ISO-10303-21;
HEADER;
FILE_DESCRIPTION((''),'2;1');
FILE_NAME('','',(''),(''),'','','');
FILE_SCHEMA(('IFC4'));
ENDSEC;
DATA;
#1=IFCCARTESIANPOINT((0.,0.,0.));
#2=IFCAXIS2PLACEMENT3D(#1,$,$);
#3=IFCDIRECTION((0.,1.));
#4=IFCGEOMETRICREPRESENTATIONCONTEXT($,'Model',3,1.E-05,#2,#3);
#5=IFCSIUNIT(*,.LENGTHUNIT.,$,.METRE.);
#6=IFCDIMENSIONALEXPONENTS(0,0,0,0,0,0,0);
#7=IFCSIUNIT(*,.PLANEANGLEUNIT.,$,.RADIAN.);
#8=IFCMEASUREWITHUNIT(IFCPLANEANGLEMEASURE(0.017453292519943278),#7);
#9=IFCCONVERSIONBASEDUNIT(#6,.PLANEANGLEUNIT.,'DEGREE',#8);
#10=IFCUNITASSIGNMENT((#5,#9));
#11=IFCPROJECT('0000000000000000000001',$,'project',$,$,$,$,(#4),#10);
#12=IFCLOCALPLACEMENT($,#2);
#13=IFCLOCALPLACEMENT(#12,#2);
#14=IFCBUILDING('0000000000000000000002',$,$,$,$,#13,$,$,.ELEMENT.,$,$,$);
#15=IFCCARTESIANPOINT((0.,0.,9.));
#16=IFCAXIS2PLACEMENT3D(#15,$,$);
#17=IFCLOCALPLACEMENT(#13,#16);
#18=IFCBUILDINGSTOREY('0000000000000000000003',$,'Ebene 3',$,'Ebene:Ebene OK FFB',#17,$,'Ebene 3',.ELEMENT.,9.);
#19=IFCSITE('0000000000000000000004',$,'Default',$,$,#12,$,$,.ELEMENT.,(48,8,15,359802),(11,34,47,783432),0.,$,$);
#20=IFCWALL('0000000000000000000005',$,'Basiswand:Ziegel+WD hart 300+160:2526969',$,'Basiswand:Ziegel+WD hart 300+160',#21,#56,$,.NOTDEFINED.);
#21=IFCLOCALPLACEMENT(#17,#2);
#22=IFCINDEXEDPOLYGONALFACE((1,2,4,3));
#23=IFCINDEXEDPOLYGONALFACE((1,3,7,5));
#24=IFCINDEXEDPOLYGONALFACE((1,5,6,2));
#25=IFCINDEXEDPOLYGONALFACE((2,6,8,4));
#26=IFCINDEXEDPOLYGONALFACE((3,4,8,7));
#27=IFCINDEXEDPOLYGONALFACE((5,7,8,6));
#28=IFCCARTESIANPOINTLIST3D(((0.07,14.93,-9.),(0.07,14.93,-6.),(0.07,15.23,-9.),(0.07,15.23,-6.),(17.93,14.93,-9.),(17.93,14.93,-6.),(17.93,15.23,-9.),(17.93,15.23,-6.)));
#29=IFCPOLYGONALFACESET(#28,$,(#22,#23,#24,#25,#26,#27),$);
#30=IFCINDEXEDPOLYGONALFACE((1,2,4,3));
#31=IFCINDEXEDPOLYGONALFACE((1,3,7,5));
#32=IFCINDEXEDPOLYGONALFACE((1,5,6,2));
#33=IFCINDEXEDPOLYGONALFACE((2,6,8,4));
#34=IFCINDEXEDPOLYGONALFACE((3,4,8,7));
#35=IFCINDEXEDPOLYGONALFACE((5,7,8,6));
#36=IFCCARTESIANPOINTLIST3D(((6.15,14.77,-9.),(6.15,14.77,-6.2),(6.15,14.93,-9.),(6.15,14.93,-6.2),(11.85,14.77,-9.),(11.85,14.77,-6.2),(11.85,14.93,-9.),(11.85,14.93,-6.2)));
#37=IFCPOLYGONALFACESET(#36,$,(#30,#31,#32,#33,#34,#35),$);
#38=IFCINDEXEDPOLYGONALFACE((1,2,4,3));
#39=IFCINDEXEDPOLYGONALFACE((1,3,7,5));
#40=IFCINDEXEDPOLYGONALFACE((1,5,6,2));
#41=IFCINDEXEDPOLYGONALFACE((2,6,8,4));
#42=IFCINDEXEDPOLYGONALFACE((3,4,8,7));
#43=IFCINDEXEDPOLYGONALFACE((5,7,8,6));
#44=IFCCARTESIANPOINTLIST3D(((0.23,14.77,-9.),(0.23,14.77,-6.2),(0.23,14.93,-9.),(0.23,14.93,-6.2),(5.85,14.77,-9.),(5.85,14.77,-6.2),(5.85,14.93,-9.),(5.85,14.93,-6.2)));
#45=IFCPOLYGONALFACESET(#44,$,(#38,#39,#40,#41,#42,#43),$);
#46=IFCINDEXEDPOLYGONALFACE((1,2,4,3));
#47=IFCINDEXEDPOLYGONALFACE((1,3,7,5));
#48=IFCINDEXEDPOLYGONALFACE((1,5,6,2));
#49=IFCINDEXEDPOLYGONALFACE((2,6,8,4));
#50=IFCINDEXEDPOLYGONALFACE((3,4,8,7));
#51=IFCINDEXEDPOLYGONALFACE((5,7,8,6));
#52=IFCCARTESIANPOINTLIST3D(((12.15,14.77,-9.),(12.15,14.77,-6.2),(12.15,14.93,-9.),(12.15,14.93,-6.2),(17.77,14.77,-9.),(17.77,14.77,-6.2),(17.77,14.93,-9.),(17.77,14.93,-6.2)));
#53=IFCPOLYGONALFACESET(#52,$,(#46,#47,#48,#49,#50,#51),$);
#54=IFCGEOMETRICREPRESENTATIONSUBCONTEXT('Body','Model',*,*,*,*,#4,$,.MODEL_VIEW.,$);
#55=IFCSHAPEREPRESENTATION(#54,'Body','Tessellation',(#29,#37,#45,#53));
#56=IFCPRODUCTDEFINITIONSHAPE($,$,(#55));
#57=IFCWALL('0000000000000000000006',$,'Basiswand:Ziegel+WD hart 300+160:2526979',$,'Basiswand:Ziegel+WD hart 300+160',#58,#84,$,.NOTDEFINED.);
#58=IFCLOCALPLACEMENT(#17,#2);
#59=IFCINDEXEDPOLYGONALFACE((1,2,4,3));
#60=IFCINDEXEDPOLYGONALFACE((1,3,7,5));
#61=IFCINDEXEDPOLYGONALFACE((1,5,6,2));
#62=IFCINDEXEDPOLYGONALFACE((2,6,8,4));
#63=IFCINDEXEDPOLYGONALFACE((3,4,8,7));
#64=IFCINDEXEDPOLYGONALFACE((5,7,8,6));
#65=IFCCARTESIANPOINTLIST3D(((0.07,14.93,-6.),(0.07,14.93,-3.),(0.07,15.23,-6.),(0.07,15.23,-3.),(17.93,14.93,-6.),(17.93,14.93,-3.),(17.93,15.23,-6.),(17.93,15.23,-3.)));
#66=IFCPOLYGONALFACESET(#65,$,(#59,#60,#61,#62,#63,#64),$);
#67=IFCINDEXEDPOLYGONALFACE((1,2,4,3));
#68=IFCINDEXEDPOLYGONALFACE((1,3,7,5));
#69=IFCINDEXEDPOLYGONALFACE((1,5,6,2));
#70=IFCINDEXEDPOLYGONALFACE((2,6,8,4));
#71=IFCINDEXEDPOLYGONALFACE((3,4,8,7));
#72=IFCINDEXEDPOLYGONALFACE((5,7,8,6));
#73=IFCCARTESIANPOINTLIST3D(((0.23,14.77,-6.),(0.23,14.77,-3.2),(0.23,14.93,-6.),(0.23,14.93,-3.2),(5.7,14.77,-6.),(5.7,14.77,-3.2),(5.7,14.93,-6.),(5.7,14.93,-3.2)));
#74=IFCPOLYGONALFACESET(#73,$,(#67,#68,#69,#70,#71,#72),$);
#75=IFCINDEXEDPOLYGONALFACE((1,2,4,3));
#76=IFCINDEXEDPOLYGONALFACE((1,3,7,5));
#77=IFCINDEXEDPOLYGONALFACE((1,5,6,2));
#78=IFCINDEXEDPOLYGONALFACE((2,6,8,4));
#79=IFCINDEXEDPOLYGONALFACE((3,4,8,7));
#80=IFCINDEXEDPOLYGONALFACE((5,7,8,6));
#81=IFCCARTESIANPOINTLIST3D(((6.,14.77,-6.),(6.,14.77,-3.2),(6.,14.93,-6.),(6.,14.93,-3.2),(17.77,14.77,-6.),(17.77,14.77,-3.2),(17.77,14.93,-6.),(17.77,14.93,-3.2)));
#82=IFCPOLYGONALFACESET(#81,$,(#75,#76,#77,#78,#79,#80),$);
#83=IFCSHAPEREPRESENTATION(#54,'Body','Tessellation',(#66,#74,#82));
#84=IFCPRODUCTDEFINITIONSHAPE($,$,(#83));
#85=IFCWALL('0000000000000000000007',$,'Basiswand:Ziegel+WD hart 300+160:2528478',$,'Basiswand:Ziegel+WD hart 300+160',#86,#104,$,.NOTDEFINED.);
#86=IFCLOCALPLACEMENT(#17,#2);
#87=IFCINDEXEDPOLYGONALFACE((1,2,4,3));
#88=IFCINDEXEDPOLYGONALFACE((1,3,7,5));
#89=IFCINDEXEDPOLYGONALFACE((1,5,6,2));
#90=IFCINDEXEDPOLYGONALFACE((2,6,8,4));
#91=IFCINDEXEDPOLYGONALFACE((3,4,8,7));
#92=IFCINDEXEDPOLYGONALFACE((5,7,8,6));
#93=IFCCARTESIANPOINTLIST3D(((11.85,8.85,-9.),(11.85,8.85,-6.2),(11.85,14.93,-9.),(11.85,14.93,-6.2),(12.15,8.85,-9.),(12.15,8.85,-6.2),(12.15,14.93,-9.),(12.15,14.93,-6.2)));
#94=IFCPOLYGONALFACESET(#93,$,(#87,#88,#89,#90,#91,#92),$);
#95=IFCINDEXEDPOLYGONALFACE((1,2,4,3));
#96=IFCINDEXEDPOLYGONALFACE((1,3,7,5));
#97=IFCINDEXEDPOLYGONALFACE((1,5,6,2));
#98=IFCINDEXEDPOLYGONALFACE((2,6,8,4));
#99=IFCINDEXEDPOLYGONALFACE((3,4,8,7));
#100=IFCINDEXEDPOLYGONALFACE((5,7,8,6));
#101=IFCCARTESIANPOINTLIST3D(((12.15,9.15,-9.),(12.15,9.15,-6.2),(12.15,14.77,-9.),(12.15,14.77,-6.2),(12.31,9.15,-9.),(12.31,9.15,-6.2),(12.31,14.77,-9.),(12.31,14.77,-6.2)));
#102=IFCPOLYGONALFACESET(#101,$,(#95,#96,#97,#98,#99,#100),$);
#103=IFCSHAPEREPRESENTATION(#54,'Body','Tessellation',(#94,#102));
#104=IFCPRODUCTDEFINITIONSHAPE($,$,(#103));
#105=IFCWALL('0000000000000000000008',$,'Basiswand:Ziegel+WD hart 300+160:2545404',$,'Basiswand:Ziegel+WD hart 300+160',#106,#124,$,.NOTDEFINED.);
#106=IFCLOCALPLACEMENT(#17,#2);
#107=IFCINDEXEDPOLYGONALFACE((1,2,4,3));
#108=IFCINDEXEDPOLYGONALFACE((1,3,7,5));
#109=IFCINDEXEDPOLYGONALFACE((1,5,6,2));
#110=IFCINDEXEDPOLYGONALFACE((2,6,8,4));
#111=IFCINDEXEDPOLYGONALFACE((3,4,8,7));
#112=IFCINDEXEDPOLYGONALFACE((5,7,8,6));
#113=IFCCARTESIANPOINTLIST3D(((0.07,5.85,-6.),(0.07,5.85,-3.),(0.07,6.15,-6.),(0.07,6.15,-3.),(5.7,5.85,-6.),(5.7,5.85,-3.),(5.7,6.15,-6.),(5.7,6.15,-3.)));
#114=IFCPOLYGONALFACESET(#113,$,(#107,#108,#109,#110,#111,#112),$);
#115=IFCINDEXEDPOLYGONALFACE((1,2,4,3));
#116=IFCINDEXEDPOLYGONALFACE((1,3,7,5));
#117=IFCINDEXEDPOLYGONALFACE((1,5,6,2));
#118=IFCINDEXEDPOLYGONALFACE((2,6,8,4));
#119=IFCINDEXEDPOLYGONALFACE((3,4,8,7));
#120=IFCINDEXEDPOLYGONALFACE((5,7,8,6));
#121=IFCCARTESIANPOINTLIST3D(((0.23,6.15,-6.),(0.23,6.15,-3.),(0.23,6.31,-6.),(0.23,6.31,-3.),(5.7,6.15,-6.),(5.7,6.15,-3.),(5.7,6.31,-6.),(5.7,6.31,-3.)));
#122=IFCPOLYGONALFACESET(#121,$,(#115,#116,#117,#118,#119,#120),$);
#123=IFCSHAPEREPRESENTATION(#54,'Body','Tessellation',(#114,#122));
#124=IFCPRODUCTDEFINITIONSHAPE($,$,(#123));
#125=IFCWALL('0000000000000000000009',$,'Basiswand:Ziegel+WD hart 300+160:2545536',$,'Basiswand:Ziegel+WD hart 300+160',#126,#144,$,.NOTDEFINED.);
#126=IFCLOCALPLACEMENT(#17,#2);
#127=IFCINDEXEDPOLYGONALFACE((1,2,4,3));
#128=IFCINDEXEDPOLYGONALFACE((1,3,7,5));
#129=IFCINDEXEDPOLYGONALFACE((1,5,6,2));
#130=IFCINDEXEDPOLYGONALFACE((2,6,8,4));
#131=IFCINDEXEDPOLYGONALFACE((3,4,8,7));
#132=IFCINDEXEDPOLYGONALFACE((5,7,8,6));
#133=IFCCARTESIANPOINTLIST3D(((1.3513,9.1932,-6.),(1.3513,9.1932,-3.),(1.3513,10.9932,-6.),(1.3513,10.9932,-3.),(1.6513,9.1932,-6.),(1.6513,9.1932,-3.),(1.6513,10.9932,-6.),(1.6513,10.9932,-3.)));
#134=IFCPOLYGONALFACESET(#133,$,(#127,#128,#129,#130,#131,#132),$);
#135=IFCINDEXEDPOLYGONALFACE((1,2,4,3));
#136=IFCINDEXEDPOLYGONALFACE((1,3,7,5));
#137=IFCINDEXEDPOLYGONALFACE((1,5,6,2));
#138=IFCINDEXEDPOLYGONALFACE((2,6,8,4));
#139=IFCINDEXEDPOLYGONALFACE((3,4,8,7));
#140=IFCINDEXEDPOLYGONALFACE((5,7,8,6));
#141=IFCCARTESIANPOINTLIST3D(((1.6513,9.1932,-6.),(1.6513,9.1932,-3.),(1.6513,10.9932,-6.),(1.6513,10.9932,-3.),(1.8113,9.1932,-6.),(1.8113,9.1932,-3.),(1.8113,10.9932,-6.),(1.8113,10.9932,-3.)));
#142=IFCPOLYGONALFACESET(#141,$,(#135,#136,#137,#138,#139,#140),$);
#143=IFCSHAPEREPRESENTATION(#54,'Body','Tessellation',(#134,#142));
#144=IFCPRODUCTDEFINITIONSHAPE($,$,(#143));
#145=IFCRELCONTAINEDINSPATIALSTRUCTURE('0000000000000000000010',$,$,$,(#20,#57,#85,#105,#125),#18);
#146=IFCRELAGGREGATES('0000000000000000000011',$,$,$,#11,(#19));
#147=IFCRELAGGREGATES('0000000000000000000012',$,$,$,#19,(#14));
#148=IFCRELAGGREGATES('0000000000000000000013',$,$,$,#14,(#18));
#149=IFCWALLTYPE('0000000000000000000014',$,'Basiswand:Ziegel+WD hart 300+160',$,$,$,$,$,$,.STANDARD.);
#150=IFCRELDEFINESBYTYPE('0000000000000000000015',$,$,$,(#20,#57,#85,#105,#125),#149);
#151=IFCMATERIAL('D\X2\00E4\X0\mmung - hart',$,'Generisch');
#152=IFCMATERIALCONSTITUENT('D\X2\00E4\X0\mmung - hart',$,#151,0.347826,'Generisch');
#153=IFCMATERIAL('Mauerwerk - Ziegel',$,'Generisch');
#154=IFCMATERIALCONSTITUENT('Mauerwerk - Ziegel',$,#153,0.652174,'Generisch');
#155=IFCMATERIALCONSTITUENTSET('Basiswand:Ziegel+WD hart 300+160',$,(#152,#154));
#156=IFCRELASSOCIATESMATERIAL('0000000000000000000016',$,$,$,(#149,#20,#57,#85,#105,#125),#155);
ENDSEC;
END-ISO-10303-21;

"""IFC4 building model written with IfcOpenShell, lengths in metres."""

from ifc_helpers import new_model, entity, si_unit, converted_unit, direction, frame, origin, place, context, subcontext, project, spatial, indexed_curve, outline, extrude, material, constituent, constituent_set, type_object, element, save


model = new_model("IFC4")

# Units and contexts
model_context = context("Model", 3, precision=1e-05, world=origin(), true_north=direction((0.0, 1.0)))
body_context = subcontext(model_context, "Body", "Model", "MODEL_VIEW")
ifc_project = project(units=[si_unit("LENGTHUNIT", "METRE"), converted_unit("PLANEANGLEUNIT", "DEGREE", entity("IfcPlaneAngleMeasure", 0.017453292519943278), si_unit("PLANEANGLEUNIT", "RADIAN"), dimensions=[0, 0, 0, 0, 0, 0, 0])], contexts=[model_context])

# Site, building, storey
site_placement = place(None, origin())
site = spatial("IfcSite", under=ifc_project, at=site_placement, Name="Default", CompositionType="ELEMENT", RefLatitude=(48, 8, 15, 359802), RefLongitude=(11, 34, 47, 783432), RefElevation=0.0)
building_placement = place(site_placement, origin())
building = spatial("IfcBuilding", under=site, at=building_placement, CompositionType="ELEMENT")
storey_placement = place(building_placement, frame((0.0, 0.0, 9.0)))
storey = spatial("IfcBuildingStorey", under=building, at=storey_placement, Name="Ebene 3", ObjectType="Ebene:Ebene OK FFB", LongName="Ebene 3", CompositionType="ELEMENT", Elevation=9.0)

# Walls
ifc_material_1 = material(Name="Dämmung - hart", Category="Generisch")
ifc_constituent_1 = constituent(ifc_material_1, Name="Dämmung - hart", Category="Generisch", fraction=0.347826)
ifc_material_2 = material(Name="Mauerwerk - Ziegel", Category="Generisch")
ifc_constituent_2 = constituent(ifc_material_2, Name="Mauerwerk - Ziegel", Category="Generisch", fraction=0.652174)
ifc_constituent_set_1 = constituent_set(constituents=[ifc_constituent_1, ifc_constituent_2], Name="Basiswand:Ziegel+WD hart 300+160")
wall_type = type_object("IfcWallType", Name="Basiswand:Ziegel+WD hart 300+160", PredefinedType="STANDARD", material=ifc_constituent_set_1)
wall_1_placement = place(storey_placement, frame((17.77, 15.0, -9.0), z_axis=(0.0, 0.0, 1.0), x_axis=(-1.0, 0.0, 0.0)))
element("IfcWall", 1, at=wall_1_placement, inside=storey, type_object=wall_type, material=ifc_constituent_set_1, Name="Basiswand:Ziegel+WD hart 300+160:2526969", ObjectType="Basiswand:Ziegel+WD hart 300+160", PredefinedType="NOTDEFINED", context=body_context, shape_type="SweptSolid", body=[
    extrude(outline(indexed_curve([(-0.15, -8.93), (0.15, -8.93), (0.15, 8.93), (-0.15, 8.93), (-0.15, -8.93)], self_intersect=False)), frame((8.77, -0.08, 0.0), z_axis=(0.0, 0.0, 1.0), x_axis=(0.0, 1.0, 0.0)), (0.0, 0.0, 1.0), 3.0),
    extrude(outline(indexed_curve([(-2.85, -0.08), (2.85, -0.08), (2.85, 0.08), (-2.85, 0.08), (-2.85, -0.08)], self_intersect=False)), frame((8.77, 0.15, 0.0)), (0.0, 0.0, 1.0), 2.8),
    extrude(outline(indexed_curve([(-2.81, -0.08), (2.81, -0.08), (2.81, 0.08), (-2.81, 0.08), (-2.81, -0.08)], self_intersect=False)), frame((14.73, 0.15, 0.0), z_axis=(0.0, 0.0, 1.0), x_axis=(-1.0, 0.0, 0.0)), (0.0, 0.0, 1.0), 2.8),
    extrude(outline(indexed_curve([(-2.81, -0.08), (2.81, -0.08), (2.81, 0.08), (-2.81, 0.08), (-2.81, -0.08)], self_intersect=False)), frame((2.81, 0.15, 0.0)), (0.0, 0.0, 1.0), 2.8),
])
wall_2_placement = place(storey_placement, frame((17.77, 15.0, -6.0), z_axis=(0.0, 0.0, 1.0), x_axis=(-1.0, 0.0, 0.0)))
element("IfcWall", 2, at=wall_2_placement, inside=storey, type_object=wall_type, material=ifc_constituent_set_1, Name="Basiswand:Ziegel+WD hart 300+160:2526979", ObjectType="Basiswand:Ziegel+WD hart 300+160", PredefinedType="NOTDEFINED", context=body_context, shape_type="SweptSolid", body=[
    extrude(outline(indexed_curve([(-0.15, -8.93), (0.15, -8.93), (0.15, 8.93), (-0.15, 8.93), (-0.15, -8.93)], self_intersect=False)), frame((8.77, -0.08, 0.0), z_axis=(0.0, 0.0, 1.0), x_axis=(0.0, 1.0, 0.0)), (0.0, 0.0, 1.0), 3.0),
    extrude(outline(indexed_curve([(-2.735, -0.08), (2.735, -0.08), (2.735, 0.08), (-2.735, 0.08), (-2.735, -0.08)], self_intersect=False)), frame((14.805, 0.15, 0.0), z_axis=(0.0, 0.0, 1.0), x_axis=(-1.0, 0.0, 0.0)), (0.0, 0.0, 1.0), 2.8),
    extrude(outline(indexed_curve([(-5.885, -0.08), (5.885, -0.08), (5.885, 0.08), (-5.885, 0.08), (-5.885, -0.08)], self_intersect=False)), frame((5.885, 0.15, 0.0)), (0.0, 0.0, 1.0), 2.8),
])

# Wall
wall_3_placement = place(storey_placement, frame((12.08, 14.77, -9.0), z_axis=(0.0, 0.0, 1.0), x_axis=(0.0, -1.0, 0.0)))
element("IfcWall", 3, at=wall_3_placement, inside=storey, type_object=wall_type, material=ifc_constituent_set_1, Name="Basiswand:Ziegel+WD hart 300+160:2528478", ObjectType="Basiswand:Ziegel+WD hart 300+160", PredefinedType="NOTDEFINED", context=body_context, shape_type="SweptSolid", body=[
    extrude(outline(indexed_curve([(-1.4, -3.04), (1.4, -3.04), (1.4, 3.04), (-1.4, 3.04), (-1.4, -3.04)], self_intersect=False)), frame((2.88, -0.23, 1.4), z_axis=(0.0, 1.0, 0.0), x_axis=(0.0, 0.0, 1.0)), (0.0, 0.0, 1.0), 0.3),
    extrude(outline(indexed_curve([(-1.4, -2.81), (1.4, -2.81), (1.4, 2.81), (-1.4, 2.81), (-1.4, -2.81)], self_intersect=False)), frame((2.81, 0.07, 1.4), z_axis=(0.0, 1.0, 0.0), x_axis=(0.0, 0.0, 1.0)), (0.0, 0.0, 1.0), 0.16),
])

# Walls
wall_4_placement = place(storey_placement, frame((0.23, 6.08, -6.0)))
element("IfcWall", 4, at=wall_4_placement, inside=storey, type_object=wall_type, material=ifc_constituent_set_1, Name="Basiswand:Ziegel+WD hart 300+160:2545404", ObjectType="Basiswand:Ziegel+WD hart 300+160", PredefinedType="NOTDEFINED", context=body_context, shape_type="SweptSolid", body=[
    extrude(outline(indexed_curve([(-0.15, -2.815), (0.15, -2.815), (0.15, 2.815), (-0.15, 2.815), (-0.15, -2.815)], self_intersect=False)), frame((2.655, -0.08, 0.0), z_axis=(0.0, 0.0, 1.0), x_axis=(0.0, 1.0, 0.0)), (0.0, 0.0, 1.0), 3.0),
    extrude(outline(indexed_curve([(-0.08, -2.735), (0.08, -2.735), (0.08, 2.735), (-0.08, 2.735), (-0.08, -2.735)], self_intersect=False)), frame((2.735, 0.15, 0.0), z_axis=(0.0, 0.0, 1.0), x_axis=(0.0, 1.0, 0.0)), (0.0, 0.0, 1.0), 3.0),
])
wall_5_placement = place(storey_placement, frame((1.5813, 10.9932, -6.0), z_axis=(0.0, 0.0, 1.0), x_axis=(0.0, -1.0, 0.0)))
element("IfcWall", 5, at=wall_5_placement, inside=storey, type_object=wall_type, material=ifc_constituent_set_1, Name="Basiswand:Ziegel+WD hart 300+160:2545536", ObjectType="Basiswand:Ziegel+WD hart 300+160", PredefinedType="NOTDEFINED", context=body_context, shape_type="SweptSolid", body=[
    extrude(outline(indexed_curve([(-0.15, -0.9), (0.15, -0.9), (0.15, 0.9), (-0.15, 0.9), (-0.15, -0.9)], self_intersect=False)), frame((0.9, -0.08, 0.0), z_axis=(0.0, 0.0, 1.0), x_axis=(0.0, 1.0, 0.0)), (0.0, 0.0, 1.0), 3.0),
    extrude(outline(indexed_curve([(-0.08, -0.9), (0.08, -0.9), (0.08, 0.9), (-0.08, 0.9), (-0.08, -0.9)], self_intersect=False)), frame((0.9, 0.15, 0.0), z_axis=(0.0, 0.0, 1.0), x_axis=(0.0, -1.0, 0.0)), (0.0, 0.0, 1.0), 3.0),
])

save(model, "model.ifc")
